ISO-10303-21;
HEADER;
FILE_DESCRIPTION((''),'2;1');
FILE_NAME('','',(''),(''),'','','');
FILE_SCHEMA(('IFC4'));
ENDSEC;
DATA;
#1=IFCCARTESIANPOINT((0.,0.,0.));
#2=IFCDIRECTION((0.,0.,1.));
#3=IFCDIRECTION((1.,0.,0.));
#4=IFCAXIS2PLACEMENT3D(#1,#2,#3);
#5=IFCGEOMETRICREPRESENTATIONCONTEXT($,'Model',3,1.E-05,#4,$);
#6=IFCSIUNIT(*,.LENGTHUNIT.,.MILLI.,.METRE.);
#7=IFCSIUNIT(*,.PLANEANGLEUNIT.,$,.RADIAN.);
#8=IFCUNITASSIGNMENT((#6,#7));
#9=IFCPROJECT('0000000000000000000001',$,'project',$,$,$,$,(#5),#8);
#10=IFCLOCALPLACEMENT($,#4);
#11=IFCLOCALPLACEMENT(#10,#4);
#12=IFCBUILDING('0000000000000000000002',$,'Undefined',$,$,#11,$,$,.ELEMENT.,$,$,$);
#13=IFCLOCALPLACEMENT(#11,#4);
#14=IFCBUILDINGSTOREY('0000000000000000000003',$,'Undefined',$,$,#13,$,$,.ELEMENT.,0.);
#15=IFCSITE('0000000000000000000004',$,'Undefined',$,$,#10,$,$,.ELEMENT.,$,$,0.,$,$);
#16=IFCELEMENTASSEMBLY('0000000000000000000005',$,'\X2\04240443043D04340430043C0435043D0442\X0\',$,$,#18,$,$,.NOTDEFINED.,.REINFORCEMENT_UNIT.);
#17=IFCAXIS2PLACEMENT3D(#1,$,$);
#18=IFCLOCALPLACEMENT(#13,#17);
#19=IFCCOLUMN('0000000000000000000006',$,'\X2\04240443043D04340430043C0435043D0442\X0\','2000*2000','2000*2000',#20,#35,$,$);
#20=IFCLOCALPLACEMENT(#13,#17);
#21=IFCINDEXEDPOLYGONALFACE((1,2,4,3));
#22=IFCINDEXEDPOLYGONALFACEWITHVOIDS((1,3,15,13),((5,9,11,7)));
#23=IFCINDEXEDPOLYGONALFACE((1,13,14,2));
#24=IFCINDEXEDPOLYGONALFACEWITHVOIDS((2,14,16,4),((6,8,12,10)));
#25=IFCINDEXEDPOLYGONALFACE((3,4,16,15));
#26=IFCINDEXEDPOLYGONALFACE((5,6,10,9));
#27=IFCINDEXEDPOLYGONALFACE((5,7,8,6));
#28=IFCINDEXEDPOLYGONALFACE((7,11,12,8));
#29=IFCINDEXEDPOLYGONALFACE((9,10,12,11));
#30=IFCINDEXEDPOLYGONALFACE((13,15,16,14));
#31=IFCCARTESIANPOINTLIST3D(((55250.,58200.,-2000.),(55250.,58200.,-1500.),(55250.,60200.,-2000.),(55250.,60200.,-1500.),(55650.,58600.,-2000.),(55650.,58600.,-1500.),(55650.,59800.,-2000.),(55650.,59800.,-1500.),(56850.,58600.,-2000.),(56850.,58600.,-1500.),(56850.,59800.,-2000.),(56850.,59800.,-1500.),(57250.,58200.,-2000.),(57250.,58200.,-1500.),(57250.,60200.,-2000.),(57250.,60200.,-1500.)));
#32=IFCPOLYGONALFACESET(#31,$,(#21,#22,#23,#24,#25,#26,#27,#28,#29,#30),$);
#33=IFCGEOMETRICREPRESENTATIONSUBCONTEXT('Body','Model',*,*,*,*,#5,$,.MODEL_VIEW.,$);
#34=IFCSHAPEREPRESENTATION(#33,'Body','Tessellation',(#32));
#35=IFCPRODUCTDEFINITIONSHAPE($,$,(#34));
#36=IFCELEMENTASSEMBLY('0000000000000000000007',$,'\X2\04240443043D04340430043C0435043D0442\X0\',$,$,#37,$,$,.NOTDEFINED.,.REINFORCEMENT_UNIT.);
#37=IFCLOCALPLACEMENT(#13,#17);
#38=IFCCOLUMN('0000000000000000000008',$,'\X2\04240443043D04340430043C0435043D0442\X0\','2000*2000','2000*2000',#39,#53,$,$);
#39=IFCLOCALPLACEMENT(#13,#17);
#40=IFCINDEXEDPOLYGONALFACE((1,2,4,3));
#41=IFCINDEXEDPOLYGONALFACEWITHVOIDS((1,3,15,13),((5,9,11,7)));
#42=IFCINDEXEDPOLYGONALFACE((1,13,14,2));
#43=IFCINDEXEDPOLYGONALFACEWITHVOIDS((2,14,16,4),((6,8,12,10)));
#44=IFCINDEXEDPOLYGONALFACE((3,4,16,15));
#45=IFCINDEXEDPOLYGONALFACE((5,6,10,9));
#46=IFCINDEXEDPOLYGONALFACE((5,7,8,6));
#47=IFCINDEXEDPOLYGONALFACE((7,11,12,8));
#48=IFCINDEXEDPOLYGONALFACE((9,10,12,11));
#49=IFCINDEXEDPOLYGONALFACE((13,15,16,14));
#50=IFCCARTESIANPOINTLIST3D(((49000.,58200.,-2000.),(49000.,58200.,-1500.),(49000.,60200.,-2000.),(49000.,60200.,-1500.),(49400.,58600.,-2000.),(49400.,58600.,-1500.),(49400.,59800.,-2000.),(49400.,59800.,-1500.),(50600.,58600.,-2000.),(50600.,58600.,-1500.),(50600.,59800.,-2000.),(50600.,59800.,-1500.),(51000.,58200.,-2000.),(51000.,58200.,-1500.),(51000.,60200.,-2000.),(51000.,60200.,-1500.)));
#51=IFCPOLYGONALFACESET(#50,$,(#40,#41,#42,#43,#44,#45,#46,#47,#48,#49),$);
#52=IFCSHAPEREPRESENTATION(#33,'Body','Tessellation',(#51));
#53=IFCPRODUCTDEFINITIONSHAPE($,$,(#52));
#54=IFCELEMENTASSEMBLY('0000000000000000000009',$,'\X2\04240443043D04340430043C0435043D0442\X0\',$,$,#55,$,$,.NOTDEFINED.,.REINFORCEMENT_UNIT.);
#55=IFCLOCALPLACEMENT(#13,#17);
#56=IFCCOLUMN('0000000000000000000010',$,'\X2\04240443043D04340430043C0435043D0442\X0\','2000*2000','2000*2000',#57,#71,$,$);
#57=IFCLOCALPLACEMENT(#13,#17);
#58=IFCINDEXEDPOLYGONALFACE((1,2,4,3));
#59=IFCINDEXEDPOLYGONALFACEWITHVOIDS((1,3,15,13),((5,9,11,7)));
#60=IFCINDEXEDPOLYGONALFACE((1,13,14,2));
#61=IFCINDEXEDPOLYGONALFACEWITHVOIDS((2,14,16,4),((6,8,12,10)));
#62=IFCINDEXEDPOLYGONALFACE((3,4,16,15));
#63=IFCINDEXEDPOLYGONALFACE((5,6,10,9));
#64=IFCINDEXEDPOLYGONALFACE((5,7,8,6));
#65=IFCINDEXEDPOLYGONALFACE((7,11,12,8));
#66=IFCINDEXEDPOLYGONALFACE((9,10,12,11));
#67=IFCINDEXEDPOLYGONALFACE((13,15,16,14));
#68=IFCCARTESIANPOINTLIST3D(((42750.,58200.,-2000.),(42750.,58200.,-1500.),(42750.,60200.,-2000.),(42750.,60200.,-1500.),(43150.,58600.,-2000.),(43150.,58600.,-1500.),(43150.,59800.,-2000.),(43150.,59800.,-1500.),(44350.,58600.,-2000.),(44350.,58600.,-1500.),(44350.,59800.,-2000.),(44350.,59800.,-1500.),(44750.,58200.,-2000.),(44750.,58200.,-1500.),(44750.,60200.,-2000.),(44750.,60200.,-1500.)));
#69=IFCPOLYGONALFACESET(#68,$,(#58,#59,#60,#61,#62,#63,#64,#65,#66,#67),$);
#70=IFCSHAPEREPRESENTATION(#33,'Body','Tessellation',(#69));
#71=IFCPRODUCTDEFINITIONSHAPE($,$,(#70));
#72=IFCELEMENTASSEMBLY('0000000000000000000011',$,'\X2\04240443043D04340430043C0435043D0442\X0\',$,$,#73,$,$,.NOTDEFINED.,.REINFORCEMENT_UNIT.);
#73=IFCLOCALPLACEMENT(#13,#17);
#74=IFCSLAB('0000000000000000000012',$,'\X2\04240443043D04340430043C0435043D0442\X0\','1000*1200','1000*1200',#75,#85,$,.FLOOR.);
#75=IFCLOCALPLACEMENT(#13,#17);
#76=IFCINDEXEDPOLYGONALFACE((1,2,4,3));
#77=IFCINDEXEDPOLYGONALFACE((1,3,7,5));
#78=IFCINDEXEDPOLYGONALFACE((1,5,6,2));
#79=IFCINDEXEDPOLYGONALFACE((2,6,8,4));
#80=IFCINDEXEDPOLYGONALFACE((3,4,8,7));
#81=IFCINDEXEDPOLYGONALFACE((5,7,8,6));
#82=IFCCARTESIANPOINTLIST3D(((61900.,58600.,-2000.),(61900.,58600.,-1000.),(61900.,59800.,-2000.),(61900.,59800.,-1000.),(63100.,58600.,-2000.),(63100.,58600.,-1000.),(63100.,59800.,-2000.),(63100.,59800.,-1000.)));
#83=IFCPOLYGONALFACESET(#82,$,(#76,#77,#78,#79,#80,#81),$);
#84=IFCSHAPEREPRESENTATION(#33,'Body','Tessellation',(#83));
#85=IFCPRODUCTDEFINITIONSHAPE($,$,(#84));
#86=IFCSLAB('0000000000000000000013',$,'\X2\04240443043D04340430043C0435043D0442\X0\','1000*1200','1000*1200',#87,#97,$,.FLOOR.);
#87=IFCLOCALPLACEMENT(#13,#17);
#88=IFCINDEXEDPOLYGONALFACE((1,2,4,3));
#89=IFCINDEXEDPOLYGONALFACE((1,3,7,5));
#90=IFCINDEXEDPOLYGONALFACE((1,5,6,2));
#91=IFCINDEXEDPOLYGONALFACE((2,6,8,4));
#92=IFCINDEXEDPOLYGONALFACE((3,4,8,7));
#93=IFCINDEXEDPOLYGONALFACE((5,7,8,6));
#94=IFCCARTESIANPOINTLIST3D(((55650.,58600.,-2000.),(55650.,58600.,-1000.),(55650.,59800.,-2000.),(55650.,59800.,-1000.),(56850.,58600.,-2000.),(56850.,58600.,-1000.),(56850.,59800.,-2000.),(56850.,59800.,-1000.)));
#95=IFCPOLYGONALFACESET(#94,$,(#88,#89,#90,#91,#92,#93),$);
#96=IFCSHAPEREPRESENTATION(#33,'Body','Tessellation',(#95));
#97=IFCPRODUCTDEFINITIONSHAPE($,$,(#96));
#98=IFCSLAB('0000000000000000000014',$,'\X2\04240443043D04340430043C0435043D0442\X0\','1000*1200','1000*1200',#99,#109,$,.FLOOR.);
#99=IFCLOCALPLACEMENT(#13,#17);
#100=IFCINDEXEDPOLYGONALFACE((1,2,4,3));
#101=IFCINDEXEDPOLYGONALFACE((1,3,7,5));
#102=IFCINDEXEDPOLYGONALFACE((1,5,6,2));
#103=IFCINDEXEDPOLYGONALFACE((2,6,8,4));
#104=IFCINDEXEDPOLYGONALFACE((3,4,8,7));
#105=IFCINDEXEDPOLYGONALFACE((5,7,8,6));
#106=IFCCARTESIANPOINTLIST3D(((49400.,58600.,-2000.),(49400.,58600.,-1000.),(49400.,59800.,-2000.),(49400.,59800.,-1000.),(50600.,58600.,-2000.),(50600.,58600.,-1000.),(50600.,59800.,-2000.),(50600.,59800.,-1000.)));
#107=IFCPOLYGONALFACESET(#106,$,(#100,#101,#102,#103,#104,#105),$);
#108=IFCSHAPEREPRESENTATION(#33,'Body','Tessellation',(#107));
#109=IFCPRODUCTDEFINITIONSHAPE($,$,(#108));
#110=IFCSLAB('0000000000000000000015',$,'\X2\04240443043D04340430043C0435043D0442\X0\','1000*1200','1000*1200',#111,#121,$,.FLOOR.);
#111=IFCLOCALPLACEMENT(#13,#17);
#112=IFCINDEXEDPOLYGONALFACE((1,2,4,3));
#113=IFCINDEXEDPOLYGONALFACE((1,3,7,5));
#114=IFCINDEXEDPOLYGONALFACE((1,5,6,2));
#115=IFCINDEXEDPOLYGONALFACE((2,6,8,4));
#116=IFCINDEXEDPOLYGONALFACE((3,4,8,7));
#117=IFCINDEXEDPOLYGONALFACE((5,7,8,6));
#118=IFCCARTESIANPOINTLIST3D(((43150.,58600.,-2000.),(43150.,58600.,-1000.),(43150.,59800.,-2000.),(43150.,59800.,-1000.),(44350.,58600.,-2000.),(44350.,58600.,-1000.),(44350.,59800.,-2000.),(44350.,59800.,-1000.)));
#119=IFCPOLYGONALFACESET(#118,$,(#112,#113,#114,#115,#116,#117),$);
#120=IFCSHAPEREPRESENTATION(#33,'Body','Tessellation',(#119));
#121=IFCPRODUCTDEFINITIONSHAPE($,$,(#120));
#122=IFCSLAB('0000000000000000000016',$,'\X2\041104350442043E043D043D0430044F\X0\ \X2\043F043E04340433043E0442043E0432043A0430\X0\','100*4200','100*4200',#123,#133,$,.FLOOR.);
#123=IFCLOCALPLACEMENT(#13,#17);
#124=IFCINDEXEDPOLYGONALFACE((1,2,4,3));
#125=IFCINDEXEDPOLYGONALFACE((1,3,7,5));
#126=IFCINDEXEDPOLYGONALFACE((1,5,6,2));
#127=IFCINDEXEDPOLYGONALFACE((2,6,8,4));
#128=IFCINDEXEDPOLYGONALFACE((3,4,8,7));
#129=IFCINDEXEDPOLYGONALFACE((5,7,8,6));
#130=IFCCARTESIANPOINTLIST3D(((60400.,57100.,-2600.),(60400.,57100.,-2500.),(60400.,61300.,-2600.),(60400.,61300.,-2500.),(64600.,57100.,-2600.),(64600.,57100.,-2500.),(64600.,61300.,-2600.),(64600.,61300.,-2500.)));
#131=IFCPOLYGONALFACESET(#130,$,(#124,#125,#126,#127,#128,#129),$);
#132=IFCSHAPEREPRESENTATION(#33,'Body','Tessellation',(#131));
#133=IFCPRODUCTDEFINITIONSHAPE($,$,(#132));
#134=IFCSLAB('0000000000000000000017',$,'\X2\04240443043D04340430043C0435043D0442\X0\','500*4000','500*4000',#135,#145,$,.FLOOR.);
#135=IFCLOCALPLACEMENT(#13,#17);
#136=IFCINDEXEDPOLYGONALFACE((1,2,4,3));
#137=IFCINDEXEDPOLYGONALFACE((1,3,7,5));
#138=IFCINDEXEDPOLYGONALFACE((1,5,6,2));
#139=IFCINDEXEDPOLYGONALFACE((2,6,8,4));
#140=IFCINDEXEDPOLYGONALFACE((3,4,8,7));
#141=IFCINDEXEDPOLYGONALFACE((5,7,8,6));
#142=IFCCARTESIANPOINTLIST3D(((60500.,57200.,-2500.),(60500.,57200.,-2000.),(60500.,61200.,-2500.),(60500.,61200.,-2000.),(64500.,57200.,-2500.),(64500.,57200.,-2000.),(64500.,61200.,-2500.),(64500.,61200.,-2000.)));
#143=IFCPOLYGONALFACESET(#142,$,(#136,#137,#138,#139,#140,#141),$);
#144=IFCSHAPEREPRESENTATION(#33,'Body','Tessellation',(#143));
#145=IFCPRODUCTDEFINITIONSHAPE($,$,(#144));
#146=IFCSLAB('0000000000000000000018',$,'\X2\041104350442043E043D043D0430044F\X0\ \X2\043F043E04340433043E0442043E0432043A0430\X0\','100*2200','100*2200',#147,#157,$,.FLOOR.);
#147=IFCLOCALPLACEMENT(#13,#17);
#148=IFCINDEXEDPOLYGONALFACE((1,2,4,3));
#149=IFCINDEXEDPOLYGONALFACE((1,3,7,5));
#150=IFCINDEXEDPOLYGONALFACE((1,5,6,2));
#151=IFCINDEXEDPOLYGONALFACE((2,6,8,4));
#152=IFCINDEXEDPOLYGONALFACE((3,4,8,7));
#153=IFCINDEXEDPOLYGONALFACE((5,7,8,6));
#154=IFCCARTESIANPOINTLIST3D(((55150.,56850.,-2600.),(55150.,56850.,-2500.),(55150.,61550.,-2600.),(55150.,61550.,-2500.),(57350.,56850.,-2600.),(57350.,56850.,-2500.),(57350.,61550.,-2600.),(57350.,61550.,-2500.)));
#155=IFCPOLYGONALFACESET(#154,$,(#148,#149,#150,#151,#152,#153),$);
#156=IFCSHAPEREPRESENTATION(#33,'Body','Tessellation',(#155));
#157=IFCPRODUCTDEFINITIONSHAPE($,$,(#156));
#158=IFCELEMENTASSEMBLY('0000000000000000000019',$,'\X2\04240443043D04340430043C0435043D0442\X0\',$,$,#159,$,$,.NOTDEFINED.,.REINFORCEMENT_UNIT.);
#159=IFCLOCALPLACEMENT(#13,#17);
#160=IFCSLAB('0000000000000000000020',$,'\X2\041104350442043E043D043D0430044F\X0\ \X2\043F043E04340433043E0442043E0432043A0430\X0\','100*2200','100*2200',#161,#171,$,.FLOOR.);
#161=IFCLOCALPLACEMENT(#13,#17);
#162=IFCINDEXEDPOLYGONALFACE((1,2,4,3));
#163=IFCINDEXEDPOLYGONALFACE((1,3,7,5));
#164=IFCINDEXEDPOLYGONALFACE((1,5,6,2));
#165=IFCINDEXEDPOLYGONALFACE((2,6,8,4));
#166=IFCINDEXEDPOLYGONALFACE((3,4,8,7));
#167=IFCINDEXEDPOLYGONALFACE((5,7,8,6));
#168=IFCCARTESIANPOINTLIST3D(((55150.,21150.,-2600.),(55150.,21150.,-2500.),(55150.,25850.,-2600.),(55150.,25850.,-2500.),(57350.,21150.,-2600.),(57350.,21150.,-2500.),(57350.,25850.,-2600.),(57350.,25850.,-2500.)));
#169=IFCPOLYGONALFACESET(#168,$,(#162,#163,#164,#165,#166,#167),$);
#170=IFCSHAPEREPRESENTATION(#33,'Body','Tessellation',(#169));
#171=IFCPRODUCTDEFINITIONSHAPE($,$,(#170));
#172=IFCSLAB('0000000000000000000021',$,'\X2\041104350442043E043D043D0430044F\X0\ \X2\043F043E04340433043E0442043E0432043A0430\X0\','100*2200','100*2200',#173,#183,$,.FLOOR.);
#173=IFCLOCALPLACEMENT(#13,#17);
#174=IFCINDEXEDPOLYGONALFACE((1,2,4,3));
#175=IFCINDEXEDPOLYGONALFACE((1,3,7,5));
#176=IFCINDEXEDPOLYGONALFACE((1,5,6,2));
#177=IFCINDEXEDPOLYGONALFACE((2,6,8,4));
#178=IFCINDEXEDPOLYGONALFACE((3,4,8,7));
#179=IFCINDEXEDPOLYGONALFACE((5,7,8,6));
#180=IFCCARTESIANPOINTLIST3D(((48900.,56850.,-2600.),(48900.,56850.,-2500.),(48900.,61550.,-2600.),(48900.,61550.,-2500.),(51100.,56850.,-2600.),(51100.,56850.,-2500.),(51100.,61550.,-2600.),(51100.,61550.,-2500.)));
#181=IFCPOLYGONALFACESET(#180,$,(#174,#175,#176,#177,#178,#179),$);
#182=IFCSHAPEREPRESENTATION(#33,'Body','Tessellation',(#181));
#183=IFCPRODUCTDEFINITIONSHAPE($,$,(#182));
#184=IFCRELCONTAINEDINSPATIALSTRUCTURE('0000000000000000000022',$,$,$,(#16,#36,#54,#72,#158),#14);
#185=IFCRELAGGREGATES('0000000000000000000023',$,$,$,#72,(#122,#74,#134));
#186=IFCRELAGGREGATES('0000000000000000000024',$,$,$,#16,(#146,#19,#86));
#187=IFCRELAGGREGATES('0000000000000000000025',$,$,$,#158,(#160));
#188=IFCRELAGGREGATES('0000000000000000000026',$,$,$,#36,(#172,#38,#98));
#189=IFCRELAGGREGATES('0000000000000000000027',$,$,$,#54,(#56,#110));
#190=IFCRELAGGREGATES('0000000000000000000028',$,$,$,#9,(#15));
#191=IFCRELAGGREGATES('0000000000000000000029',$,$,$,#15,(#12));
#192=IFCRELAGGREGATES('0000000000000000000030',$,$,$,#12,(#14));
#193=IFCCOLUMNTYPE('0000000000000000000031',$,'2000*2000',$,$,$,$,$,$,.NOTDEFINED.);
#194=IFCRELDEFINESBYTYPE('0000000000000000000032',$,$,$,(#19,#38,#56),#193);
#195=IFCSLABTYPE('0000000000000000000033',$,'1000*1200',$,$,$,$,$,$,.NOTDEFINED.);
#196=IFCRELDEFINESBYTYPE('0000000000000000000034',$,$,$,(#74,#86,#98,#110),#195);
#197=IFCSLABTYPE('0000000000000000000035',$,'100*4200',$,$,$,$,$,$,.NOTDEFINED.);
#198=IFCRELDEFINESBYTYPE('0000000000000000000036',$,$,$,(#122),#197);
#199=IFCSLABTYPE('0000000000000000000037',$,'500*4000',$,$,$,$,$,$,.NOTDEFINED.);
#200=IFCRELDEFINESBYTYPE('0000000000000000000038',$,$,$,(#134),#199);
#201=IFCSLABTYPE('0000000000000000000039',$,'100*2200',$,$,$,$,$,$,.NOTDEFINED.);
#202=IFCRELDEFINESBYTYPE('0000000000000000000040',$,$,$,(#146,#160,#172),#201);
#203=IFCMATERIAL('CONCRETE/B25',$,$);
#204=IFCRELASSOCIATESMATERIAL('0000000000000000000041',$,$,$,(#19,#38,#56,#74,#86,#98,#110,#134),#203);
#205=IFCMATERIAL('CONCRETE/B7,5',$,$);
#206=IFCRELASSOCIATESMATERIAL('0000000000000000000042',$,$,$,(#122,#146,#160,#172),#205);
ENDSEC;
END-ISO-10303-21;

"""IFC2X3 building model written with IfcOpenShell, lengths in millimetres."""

from ifc_helpers import new_model, si_unit, frame, origin_with_axes, origin_2d_with_axis, place, context, subcontext, project, spatial, polyline, rectangle, outline, extrude, boolean, material, type_object, element, aggregate, save


model = new_model("IFC2X3")

# Units and contexts
model_context = context("Model", 3, precision=1e-05, world=origin_with_axes())
body_context = subcontext(model_context, "Body", "Model", "MODEL_VIEW")
ifc_project = project(units=[si_unit("LENGTHUNIT", "METRE", prefix="MILLI"), si_unit("PLANEANGLEUNIT", "RADIAN")], contexts=[model_context])

# Site, building, storey
site_placement = place(None, origin_with_axes())
site = spatial("IfcSite", under=ifc_project, at=site_placement, Name="Undefined", CompositionType="ELEMENT", RefElevation=0.0)
building_placement = place(site_placement, origin_with_axes())
building = spatial("IfcBuilding", under=site, at=building_placement, Name="Undefined", CompositionType="ELEMENT")
storey_placement = place(building_placement, origin_with_axes())
storey = spatial("IfcBuildingStorey", under=building, at=storey_placement, Name="Undefined", CompositionType="ELEMENT", Elevation=0.0)

# Element assemblies, columns
assembly_1_placement = place(storey_placement, origin_with_axes())
assembly_1 = element("IfcElementAssembly", 1, at=assembly_1_placement, inside=storey, Name="Фундамент", AssemblyPlace="NOTDEFINED", PredefinedType="REINFORCEMENT_UNIT")
ifc_material_1 = material(Name="CONCRETE/B25")
column_type = type_object("IfcColumnType", Name="2000*2000", PredefinedType="NOTDEFINED")
column_1_placement = place(assembly_1_placement, frame((56250.0, 59200.0, -2000.0), z_axis=(0.0, 0.0, 1.0), x_axis=(0.0, -1.0, 0.0)))
column_1 = element("IfcColumn", 2, at=column_1_placement, type_object=column_type, material=ifc_material_1, Name="Фундамент", Description="2000*2000", ObjectType="2000*2000", context=body_context, shape_type="CSG", body=[
    boolean("DIFFERENCE", extrude(rectangle(XDim=2000.0, YDim=2000.0, at=origin_2d_with_axis()), frame((0.0, 0.0, 500.0), z_axis=(0.0, 0.0, -1.0), x_axis=(0.0, 1.0, 0.0)), (0.0, 0.0, 1.0), 500.0), extrude(outline(polyline([(0.0, 0.0), (1200.0, 0.0), (1200.0, 1200.0), (0.0, 1200.0), (0.0, 0.0)])), frame((-600.0, -600.0, -100.0), z_axis=(0.0, 0.0, 1.0), x_axis=(1.0, 0.0, 0.0)), (0.0, 0.0, 1.0), 700.0)),
])
assembly_2_placement = place(storey_placement, origin_with_axes())
assembly_2 = element("IfcElementAssembly", 3, at=assembly_2_placement, inside=storey, Name="Фундамент", AssemblyPlace="NOTDEFINED", PredefinedType="REINFORCEMENT_UNIT")
column_2_placement = place(assembly_2_placement, frame((50000.0, 59200.0, -2000.0), z_axis=(0.0, 0.0, 1.0), x_axis=(0.0, -1.0, 0.0)))
column_2 = element("IfcColumn", 4, at=column_2_placement, type_object=column_type, material=ifc_material_1, Name="Фундамент", Description="2000*2000", ObjectType="2000*2000", context=body_context, shape_type="CSG", body=[
    boolean("DIFFERENCE", extrude(rectangle(XDim=2000.0, YDim=2000.0, at=origin_2d_with_axis()), frame((0.0, 0.0, 500.0), z_axis=(0.0, 0.0, -1.0), x_axis=(0.0, 1.0, 0.0)), (0.0, 0.0, 1.0), 500.0), extrude(outline(polyline([(0.0, 0.0), (1200.0, 0.0), (1200.0, 1200.0), (0.0, 1200.0), (0.0, 0.0)])), frame((-600.0, -600.0, -100.0), z_axis=(0.0, 0.0, 1.0), x_axis=(1.0, 0.0, 0.0)), (0.0, 0.0, 1.0), 700.0)),
])
assembly_3_placement = place(storey_placement, origin_with_axes())
assembly_3 = element("IfcElementAssembly", 5, at=assembly_3_placement, inside=storey, Name="Фундамент", AssemblyPlace="NOTDEFINED", PredefinedType="REINFORCEMENT_UNIT")
column_3_placement = place(assembly_3_placement, frame((43750.0, 59200.0, -2000.0), z_axis=(0.0, 0.0, 1.0), x_axis=(0.0, -1.0, 0.0)))
column_3 = element("IfcColumn", 6, at=column_3_placement, type_object=column_type, material=ifc_material_1, Name="Фундамент", Description="2000*2000", ObjectType="2000*2000", context=body_context, shape_type="CSG", body=[
    boolean("DIFFERENCE", extrude(rectangle(XDim=2000.0, YDim=2000.0, at=origin_2d_with_axis()), frame((0.0, 0.0, 500.0), z_axis=(0.0, 0.0, -1.0), x_axis=(0.0, 1.0, 0.0)), (0.0, 0.0, 1.0), 500.0), extrude(outline(polyline([(0.0, 0.0), (1200.0, 0.0), (1200.0, 1200.0), (0.0, 1200.0), (0.0, 0.0)])), frame((-600.0, -600.0, -100.0), z_axis=(0.0, 0.0, 1.0), x_axis=(1.0, 0.0, 0.0)), (0.0, 0.0, 1.0), 700.0)),
])

# Element assembly, slab
assembly_4_placement = place(storey_placement, origin_with_axes())
assembly_4 = element("IfcElementAssembly", 7, at=assembly_4_placement, inside=storey, Name="Фундамент", AssemblyPlace="NOTDEFINED", PredefinedType="REINFORCEMENT_UNIT")
slab_type_1 = type_object("IfcSlabType", Name="1000*1200", PredefinedType="NOTDEFINED")
slab_1_placement = place(assembly_4_placement, frame((61900.0, 59800.0, -1500.0), z_axis=(0.0, 0.0, 1.0), x_axis=(0.0, -1.0, 0.0)))
slab_1 = element("IfcSlab", 8, at=slab_1_placement, type_object=slab_type_1, material=ifc_material_1, Name="Фундамент", Description="1000*1200", ObjectType="1000*1200", PredefinedType="FLOOR", context=body_context, shape_type="SweptSolid", body=[
    extrude(outline(polyline([(0.0, 0.0), (1200.0, 0.0), (1200.0, 1200.0), (0.0, 1200.0), (0.0, 0.0)])), frame((0.0, 0.0, -500.0), z_axis=(0.0, 0.0, 1.0), x_axis=(1.0, 0.0, 0.0)), (0.0, 0.0, 1.0), 1000.0),
])

# Slabs
slab_2_placement = place(assembly_1_placement, frame((55650.0, 59800.0, -1500.0), z_axis=(0.0, 0.0, 1.0), x_axis=(0.0, -1.0, 0.0)))
slab_2 = element("IfcSlab", 9, at=slab_2_placement, type_object=slab_type_1, material=ifc_material_1, Name="Фундамент", Description="1000*1200", ObjectType="1000*1200", PredefinedType="FLOOR", context=body_context, shape_type="SweptSolid", body=[
    extrude(outline(polyline([(0.0, 0.0), (1200.0, 0.0), (1200.0, 1200.0), (0.0, 1200.0), (0.0, 0.0)])), frame((0.0, 0.0, -500.0), z_axis=(0.0, 0.0, 1.0), x_axis=(1.0, 0.0, 0.0)), (0.0, 0.0, 1.0), 1000.0),
])
slab_3_placement = place(assembly_2_placement, frame((49400.0, 59800.0, -1500.0), z_axis=(0.0, 0.0, 1.0), x_axis=(0.0, -1.0, 0.0)))
slab_3 = element("IfcSlab", 10, at=slab_3_placement, type_object=slab_type_1, material=ifc_material_1, Name="Фундамент", Description="1000*1200", ObjectType="1000*1200", PredefinedType="FLOOR", context=body_context, shape_type="SweptSolid", body=[
    extrude(outline(polyline([(0.0, 0.0), (1200.0, 0.0), (1200.0, 1200.0), (0.0, 1200.0), (0.0, 0.0)])), frame((0.0, 0.0, -500.0), z_axis=(0.0, 0.0, 1.0), x_axis=(1.0, 0.0, 0.0)), (0.0, 0.0, 1.0), 1000.0),
])
slab_4_placement = place(assembly_3_placement, frame((43150.0, 59800.0, -1500.0), z_axis=(0.0, 0.0, 1.0), x_axis=(0.0, -1.0, 0.0)))
slab_4 = element("IfcSlab", 11, at=slab_4_placement, type_object=slab_type_1, material=ifc_material_1, Name="Фундамент", Description="1000*1200", ObjectType="1000*1200", PredefinedType="FLOOR", context=body_context, shape_type="SweptSolid", body=[
    extrude(outline(polyline([(0.0, 0.0), (1200.0, 0.0), (1200.0, 1200.0), (0.0, 1200.0), (0.0, 0.0)])), frame((0.0, 0.0, -500.0), z_axis=(0.0, 0.0, 1.0), x_axis=(1.0, 0.0, 0.0)), (0.0, 0.0, 1.0), 1000.0),
])
ifc_material_2 = material(Name="CONCRETE/B7,5")
slab_type_2 = type_object("IfcSlabType", Name="100*4200", PredefinedType="NOTDEFINED")
slab_5_placement = place(assembly_4_placement, frame((60400.0, 61300.0, -2550.0), z_axis=(0.0, 0.0, 1.0), x_axis=(0.0, -1.0, 0.0)))
slab_5 = element("IfcSlab", 12, at=slab_5_placement, type_object=slab_type_2, material=ifc_material_2, Name="Бетонная подготовка", Description="100*4200", ObjectType="100*4200", PredefinedType="FLOOR", context=body_context, shape_type="SweptSolid", body=[
    extrude(outline(polyline([(0.0, 0.0), (4200.0, 0.0), (4200.0, 4200.0), (0.0, 4200.0), (0.0, 0.0)])), frame((0.0, 0.0, -50.0), z_axis=(0.0, 0.0, 1.0), x_axis=(1.0, 0.0, 0.0)), (0.0, 0.0, 1.0), 100.0),
])
slab_type_3 = type_object("IfcSlabType", Name="500*4000", PredefinedType="NOTDEFINED")
slab_6_placement = place(assembly_4_placement, frame((60500.0, 61200.0, -2250.0), z_axis=(0.0, 0.0, 1.0), x_axis=(0.0, -1.0, 0.0)))
slab_6 = element("IfcSlab", 13, at=slab_6_placement, type_object=slab_type_3, material=ifc_material_1, Name="Фундамент", Description="500*4000", ObjectType="500*4000", PredefinedType="FLOOR", context=body_context, shape_type="SweptSolid", body=[
    extrude(outline(polyline([(0.0, 0.0), (4000.0, 0.0), (4000.0, 4000.0), (0.0, 4000.0), (0.0, 0.0)])), frame((0.0, 0.0, -250.0), z_axis=(0.0, 0.0, 1.0), x_axis=(1.0, 0.0, 0.0)), (0.0, 0.0, 1.0), 500.0),
])
aggregate(assembly_4, [slab_5, slab_1, slab_6])
slab_type_4 = type_object("IfcSlabType", Name="100*2200", PredefinedType="NOTDEFINED")
slab_7_placement = place(assembly_1_placement, frame((55150.0, 61550.0, -2550.0), z_axis=(0.0, 0.0, 1.0), x_axis=(0.0, -1.0, 0.0)))
slab_7 = element("IfcSlab", 14, at=slab_7_placement, type_object=slab_type_4, material=ifc_material_2, Name="Бетонная подготовка", Description="100*2200", ObjectType="100*2200", PredefinedType="FLOOR", context=body_context, shape_type="SweptSolid", body=[
    extrude(outline(polyline([(0.0, 0.0), (4700.0, 0.0), (4700.0, 2200.0), (0.0, 2200.0), (0.0, 0.0)])), frame((0.0, 0.0, -50.0), z_axis=(0.0, 0.0, 1.0), x_axis=(1.0, 0.0, 0.0)), (0.0, 0.0, 1.0), 100.0),
])

# Element assembly, slab
assembly_5_placement = place(storey_placement, origin_with_axes())
assembly_5 = element("IfcElementAssembly", 15, at=assembly_5_placement, inside=storey, Name="Фундамент", AssemblyPlace="NOTDEFINED", PredefinedType="REINFORCEMENT_UNIT")
slab_8_placement = place(assembly_5_placement, frame((55150.0, 25850.0, -2550.0), z_axis=(0.0, 0.0, 1.0), x_axis=(0.0, -1.0, 0.0)))
slab_8 = element("IfcSlab", 16, at=slab_8_placement, type_object=slab_type_4, material=ifc_material_2, Name="Бетонная подготовка", Description="100*2200", ObjectType="100*2200", PredefinedType="FLOOR", context=body_context, shape_type="SweptSolid", body=[
    extrude(outline(polyline([(0.0, 0.0), (4700.0, 0.0), (4700.0, 2200.0), (0.0, 2200.0), (0.0, 0.0)])), frame((0.0, 0.0, -50.0), z_axis=(0.0, 0.0, 1.0), x_axis=(1.0, 0.0, 0.0)), (0.0, 0.0, 1.0), 100.0),
])

# Slab
slab_9_placement = place(assembly_2_placement, frame((48900.0, 61550.0, -2550.0), z_axis=(0.0, 0.0, 1.0), x_axis=(0.0, -1.0, 0.0)))
slab_9 = element("IfcSlab", 17, at=slab_9_placement, type_object=slab_type_4, material=ifc_material_2, Name="Бетонная подготовка", Description="100*2200", ObjectType="100*2200", PredefinedType="FLOOR", context=body_context, shape_type="SweptSolid", body=[
    extrude(outline(polyline([(0.0, 0.0), (4700.0, 0.0), (4700.0, 2200.0), (0.0, 2200.0), (0.0, 0.0)])), frame((0.0, 0.0, -50.0), z_axis=(0.0, 0.0, 1.0), x_axis=(1.0, 0.0, 0.0)), (0.0, 0.0, 1.0), 100.0),
])

aggregate(assembly_1, [slab_7, column_1, slab_2])
aggregate(assembly_5, [slab_8])
aggregate(assembly_2, [slab_9, column_2, slab_3])
aggregate(assembly_3, [column_3, slab_4])

save(model, "model.ifc")
